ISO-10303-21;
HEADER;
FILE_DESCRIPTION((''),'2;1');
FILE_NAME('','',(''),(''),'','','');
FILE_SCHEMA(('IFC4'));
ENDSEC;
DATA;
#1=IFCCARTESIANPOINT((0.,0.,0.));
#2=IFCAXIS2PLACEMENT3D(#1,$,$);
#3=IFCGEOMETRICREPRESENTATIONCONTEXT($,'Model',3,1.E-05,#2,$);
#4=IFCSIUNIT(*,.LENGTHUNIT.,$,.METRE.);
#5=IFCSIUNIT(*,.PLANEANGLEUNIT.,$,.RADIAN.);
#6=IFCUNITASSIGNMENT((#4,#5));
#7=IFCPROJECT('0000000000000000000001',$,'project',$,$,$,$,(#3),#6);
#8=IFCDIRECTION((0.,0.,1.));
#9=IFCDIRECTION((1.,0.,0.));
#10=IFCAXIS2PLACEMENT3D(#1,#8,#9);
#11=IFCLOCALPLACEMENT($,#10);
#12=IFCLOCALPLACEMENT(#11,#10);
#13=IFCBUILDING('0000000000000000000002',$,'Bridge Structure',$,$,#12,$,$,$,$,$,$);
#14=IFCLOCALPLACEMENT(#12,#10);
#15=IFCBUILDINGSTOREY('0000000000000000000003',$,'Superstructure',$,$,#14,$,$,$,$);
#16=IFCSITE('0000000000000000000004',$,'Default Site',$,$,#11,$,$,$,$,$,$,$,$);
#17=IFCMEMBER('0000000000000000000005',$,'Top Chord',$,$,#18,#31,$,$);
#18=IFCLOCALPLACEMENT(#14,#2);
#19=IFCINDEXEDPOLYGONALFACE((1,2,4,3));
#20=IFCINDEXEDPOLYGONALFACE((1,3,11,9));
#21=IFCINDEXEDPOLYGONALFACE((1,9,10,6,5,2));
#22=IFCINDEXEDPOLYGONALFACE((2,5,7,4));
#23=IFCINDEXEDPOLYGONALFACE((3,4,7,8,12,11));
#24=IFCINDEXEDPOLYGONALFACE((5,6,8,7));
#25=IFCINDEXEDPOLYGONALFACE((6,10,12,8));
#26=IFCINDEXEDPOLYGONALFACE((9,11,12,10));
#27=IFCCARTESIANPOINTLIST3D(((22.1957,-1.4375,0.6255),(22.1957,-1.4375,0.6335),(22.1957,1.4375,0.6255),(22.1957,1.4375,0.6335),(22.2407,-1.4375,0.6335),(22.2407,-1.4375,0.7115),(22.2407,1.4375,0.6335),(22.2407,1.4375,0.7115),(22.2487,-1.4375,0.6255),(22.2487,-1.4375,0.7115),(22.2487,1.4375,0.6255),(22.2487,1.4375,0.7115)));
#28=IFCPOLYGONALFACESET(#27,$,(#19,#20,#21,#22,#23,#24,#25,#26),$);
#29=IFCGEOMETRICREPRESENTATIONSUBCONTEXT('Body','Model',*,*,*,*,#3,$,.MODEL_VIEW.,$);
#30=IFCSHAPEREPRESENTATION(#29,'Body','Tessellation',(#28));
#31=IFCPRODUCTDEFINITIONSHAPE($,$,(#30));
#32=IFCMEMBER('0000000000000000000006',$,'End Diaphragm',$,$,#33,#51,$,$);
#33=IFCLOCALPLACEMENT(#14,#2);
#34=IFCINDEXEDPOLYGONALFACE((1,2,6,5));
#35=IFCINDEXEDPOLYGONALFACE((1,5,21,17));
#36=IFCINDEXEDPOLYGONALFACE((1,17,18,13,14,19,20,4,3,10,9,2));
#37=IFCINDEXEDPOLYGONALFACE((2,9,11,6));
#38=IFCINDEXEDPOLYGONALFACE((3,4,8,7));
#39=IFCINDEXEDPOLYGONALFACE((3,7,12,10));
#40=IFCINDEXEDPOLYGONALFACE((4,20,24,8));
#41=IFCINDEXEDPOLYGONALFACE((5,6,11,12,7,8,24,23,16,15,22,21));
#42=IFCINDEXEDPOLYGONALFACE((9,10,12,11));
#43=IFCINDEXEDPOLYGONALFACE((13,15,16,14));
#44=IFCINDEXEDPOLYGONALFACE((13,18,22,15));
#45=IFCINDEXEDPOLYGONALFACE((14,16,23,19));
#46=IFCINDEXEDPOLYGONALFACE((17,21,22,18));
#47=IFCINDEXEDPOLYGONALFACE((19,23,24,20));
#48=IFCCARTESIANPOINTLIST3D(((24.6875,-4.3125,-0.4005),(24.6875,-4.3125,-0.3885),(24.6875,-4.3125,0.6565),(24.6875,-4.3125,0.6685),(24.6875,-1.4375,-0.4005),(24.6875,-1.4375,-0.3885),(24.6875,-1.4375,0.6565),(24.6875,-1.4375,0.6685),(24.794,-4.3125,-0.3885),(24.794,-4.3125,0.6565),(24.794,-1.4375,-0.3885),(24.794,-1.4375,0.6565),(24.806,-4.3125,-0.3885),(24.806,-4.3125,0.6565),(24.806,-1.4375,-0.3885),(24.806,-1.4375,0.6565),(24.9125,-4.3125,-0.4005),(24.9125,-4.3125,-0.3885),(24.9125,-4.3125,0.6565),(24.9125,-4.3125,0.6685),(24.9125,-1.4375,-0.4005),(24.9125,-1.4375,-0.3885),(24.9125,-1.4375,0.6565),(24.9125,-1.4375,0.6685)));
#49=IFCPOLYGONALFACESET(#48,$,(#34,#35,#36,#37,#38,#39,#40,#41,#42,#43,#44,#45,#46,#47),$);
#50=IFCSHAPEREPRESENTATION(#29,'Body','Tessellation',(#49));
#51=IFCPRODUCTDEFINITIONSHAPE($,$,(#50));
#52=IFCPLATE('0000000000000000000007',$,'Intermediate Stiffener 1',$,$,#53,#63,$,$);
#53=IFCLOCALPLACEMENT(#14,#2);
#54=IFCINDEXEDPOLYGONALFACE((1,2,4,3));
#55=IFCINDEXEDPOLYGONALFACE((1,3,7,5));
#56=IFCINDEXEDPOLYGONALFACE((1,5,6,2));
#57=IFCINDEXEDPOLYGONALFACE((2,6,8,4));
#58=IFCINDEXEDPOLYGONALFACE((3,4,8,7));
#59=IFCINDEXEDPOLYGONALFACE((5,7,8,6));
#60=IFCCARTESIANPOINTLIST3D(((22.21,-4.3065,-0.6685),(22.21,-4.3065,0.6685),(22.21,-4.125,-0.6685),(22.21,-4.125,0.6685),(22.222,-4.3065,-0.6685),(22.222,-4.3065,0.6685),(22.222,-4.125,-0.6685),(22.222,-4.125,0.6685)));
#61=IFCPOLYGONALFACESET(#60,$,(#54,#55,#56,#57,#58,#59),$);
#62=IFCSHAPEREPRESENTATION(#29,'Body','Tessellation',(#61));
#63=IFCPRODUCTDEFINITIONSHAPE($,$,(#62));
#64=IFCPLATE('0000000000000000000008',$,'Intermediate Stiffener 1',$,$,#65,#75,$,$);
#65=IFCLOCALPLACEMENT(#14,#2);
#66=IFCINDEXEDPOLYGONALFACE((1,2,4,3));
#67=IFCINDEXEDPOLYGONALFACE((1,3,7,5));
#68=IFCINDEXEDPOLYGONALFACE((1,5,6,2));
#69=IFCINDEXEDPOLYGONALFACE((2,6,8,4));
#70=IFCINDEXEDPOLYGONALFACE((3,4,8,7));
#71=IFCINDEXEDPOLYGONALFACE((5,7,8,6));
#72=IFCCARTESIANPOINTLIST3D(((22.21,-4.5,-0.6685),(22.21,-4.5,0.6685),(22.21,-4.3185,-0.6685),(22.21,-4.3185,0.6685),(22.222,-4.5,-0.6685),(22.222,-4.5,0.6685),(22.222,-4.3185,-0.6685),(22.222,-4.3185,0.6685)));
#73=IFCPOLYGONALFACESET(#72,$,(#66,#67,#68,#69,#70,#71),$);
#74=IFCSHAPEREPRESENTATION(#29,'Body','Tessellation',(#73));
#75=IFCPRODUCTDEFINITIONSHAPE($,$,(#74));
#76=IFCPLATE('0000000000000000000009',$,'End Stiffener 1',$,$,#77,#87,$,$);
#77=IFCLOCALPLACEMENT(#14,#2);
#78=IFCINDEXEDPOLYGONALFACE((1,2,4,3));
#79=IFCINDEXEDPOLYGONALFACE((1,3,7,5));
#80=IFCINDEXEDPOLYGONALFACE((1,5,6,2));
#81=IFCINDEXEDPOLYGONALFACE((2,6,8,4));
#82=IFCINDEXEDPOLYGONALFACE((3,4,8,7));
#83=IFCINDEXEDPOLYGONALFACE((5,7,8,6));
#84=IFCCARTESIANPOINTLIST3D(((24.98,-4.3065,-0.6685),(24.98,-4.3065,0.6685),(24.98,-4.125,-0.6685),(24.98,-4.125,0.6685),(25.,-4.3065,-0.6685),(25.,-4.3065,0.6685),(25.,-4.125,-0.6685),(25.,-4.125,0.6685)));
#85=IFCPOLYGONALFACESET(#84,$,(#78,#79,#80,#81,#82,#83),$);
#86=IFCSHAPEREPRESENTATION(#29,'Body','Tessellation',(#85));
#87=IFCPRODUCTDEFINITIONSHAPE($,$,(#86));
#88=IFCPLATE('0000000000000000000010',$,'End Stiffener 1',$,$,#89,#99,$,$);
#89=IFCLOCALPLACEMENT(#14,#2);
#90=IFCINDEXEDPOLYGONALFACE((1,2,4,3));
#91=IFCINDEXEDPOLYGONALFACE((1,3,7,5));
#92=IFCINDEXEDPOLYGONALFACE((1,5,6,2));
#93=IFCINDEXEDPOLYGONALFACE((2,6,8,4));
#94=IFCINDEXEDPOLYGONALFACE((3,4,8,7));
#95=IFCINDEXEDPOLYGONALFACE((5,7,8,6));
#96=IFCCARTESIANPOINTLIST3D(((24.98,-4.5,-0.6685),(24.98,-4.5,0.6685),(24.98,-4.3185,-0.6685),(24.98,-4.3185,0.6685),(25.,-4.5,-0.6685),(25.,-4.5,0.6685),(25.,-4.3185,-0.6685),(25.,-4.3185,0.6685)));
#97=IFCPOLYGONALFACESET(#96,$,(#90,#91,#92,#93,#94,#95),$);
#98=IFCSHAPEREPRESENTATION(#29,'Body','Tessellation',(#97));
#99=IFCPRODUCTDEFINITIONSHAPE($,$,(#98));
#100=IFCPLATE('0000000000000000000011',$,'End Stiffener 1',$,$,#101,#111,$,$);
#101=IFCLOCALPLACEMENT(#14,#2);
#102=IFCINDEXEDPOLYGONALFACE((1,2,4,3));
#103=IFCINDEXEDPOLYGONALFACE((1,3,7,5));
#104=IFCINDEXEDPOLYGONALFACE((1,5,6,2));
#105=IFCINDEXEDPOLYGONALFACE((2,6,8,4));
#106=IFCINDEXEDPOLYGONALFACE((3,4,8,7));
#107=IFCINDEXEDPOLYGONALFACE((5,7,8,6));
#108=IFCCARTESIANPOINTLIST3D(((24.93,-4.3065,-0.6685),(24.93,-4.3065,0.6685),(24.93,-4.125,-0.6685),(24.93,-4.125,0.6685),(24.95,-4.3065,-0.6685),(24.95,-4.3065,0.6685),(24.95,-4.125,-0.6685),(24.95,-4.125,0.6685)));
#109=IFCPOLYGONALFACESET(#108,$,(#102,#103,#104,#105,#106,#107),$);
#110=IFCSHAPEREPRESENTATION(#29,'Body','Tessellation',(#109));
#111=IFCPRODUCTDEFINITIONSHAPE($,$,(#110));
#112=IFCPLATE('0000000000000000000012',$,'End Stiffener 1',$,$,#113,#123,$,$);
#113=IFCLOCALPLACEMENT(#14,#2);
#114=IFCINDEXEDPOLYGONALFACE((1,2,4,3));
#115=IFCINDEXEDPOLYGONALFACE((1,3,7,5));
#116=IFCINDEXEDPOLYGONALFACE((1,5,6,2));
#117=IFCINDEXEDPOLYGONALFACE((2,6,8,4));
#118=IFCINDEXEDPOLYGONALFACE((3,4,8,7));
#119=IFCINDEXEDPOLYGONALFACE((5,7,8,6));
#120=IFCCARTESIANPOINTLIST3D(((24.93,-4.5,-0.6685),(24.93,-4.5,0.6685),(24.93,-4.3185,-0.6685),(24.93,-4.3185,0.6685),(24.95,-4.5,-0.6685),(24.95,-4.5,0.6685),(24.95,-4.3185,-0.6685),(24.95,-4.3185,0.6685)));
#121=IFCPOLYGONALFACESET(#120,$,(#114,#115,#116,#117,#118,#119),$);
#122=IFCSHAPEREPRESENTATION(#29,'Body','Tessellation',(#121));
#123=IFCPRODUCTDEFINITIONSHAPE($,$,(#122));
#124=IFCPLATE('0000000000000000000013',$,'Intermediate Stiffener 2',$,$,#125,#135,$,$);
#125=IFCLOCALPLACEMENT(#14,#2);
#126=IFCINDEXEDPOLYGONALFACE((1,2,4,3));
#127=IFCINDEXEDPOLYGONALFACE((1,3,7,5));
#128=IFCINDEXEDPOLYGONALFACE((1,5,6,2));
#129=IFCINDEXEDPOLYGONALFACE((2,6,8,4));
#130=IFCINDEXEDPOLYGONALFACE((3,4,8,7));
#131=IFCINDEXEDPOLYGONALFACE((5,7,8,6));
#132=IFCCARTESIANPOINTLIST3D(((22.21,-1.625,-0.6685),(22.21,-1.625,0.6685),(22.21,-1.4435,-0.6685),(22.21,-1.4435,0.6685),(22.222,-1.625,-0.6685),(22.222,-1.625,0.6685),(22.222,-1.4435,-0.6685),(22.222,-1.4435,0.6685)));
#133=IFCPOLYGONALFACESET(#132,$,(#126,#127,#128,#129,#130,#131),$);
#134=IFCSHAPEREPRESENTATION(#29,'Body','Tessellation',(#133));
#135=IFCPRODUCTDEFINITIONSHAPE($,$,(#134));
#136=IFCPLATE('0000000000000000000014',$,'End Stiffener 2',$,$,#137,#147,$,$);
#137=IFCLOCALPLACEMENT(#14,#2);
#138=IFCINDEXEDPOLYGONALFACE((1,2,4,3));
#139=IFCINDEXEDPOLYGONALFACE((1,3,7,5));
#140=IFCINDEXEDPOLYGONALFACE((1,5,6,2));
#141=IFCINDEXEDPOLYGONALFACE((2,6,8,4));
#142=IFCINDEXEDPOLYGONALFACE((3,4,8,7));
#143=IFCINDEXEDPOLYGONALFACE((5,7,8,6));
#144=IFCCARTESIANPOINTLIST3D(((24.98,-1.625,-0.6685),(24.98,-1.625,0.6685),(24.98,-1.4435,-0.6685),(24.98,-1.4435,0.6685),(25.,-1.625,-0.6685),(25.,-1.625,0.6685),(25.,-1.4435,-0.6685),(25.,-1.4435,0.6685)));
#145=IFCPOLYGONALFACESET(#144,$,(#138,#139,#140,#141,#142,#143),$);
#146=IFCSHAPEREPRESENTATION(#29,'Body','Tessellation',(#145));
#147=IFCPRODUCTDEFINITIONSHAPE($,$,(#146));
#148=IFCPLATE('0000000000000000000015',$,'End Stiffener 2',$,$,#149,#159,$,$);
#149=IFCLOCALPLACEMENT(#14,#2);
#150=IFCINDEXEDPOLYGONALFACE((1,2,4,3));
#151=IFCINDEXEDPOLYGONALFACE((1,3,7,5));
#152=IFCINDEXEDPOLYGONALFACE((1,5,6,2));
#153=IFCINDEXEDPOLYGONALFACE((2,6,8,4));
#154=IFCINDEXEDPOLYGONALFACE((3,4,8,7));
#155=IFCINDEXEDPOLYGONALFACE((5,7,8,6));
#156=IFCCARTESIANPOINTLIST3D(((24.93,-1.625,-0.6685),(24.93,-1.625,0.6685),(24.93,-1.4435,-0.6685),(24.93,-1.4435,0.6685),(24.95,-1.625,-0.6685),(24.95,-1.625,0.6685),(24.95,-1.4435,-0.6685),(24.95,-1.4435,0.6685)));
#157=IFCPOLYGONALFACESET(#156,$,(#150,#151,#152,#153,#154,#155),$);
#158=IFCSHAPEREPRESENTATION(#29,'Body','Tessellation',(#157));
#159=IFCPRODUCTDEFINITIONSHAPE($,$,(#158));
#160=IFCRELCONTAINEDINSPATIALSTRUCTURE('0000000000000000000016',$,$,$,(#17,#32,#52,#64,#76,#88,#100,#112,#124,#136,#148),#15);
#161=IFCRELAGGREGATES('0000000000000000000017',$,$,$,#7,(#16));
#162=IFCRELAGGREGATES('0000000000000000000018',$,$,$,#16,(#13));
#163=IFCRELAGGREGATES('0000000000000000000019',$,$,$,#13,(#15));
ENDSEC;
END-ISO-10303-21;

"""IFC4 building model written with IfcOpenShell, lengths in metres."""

from ifc_helpers import new_model, si_unit, frame, origin, origin_with_axes, origin_2d_with_axis, place, context, subcontext, project, spatial, rectangle, i_section, l_section, extrude, element, save


model = new_model("IFC4")

# Units and contexts
model_context = context("Model", 3, precision=1e-05, world=origin())
body_context = subcontext(model_context, "Body", "Model", "MODEL_VIEW")
ifc_project = project(units=[si_unit("LENGTHUNIT", "METRE"), si_unit("PLANEANGLEUNIT", "RADIAN")], contexts=[model_context])

# Site, building, storey
site_placement = place(None, origin_with_axes())
site = spatial("IfcSite", under=ifc_project, at=site_placement, Name="Default Site")
building_placement = place(site_placement, origin_with_axes())
building = spatial("IfcBuilding", under=site, at=building_placement, Name="Bridge Structure")
storey_placement = place(building_placement, origin_with_axes())
storey = spatial("IfcBuildingStorey", under=building, at=storey_placement, Name="Superstructure")

# Members
for number, where, z_axis, x_axis, name in (
    (1, (22.2222, -1.4375, 0.6685), (0.0, 1.0, 0.0), (-1.0, 0.0, 0.0), "Top Chord"),
):
    element("IfcMember", number, at=place(storey_placement, frame(where, z_axis=z_axis, x_axis=x_axis)), inside=storey, Name=name, context=body_context, shape_type="SweptSolid", body=[
        extrude(l_section(Depth=0.086, Width=0.053, Thickness=0.008, at=origin_2d_with_axis()), origin_with_axes(), (0.0, 0.0, 1.0), 2.875),
    ])
member_placement = place(storey_placement, frame((24.8, -4.3125, 0.134), z_axis=(0.0, 1.0, 0.0), x_axis=(-1.0, 0.0, 0.0)))
element("IfcMember", 2, at=member_placement, inside=storey, Name="End Diaphragm", context=body_context, shape_type="SweptSolid", body=[
    extrude(i_section(OverallWidth=0.225, OverallDepth=1.069, WebThickness=0.012, FlangeThickness=0.012, at=origin_2d_with_axis()), origin_with_axes(), (0.0, 0.0, 1.0), 2.875),
])

# Plates
for number, where, z_axis, x_axis, name in (
    (3, (22.216, -4.2157, -0.6685), (0.0, 0.0, 1.0), (1.0, 0.0, 0.0), "Intermediate Stiffener 1"),
    (4, (22.216, -4.4093, -0.6685), (0.0, 0.0, 1.0), (1.0, 0.0, 0.0), "Intermediate Stiffener 1"),
):
    element("IfcPlate", number, at=place(storey_placement, frame(where, z_axis=z_axis, x_axis=x_axis)), inside=storey, Name=name, context=body_context, shape_type="SweptSolid", body=[
        extrude(rectangle(XDim=0.012, YDim=0.1815, at=origin_2d_with_axis()), origin_with_axes(), (0.0, 0.0, 1.0), 1.337),
    ])
for number, where, z_axis, x_axis, name in (
    (5, (24.99, -4.2157, -0.6685), (0.0, 0.0, 1.0), (1.0, 0.0, 0.0), "End Stiffener 1"),
    (6, (24.99, -4.4093, -0.6685), (0.0, 0.0, 1.0), (1.0, 0.0, 0.0), "End Stiffener 1"),
    (7, (24.94, -4.2157, -0.6685), (0.0, 0.0, 1.0), (1.0, 0.0, 0.0), "End Stiffener 1"),
    (8, (24.94, -4.4093, -0.6685), (0.0, 0.0, 1.0), (1.0, 0.0, 0.0), "End Stiffener 1"),
):
    element("IfcPlate", number, at=place(storey_placement, frame(where, z_axis=z_axis, x_axis=x_axis)), inside=storey, Name=name, context=body_context, shape_type="SweptSolid", body=[
        extrude(rectangle(XDim=0.02, YDim=0.1815, at=origin_2d_with_axis()), origin_with_axes(), (0.0, 0.0, 1.0), 1.337),
    ])
plate_placement = place(storey_placement, frame((22.216, -1.5343, -0.6685), z_axis=(0.0, 0.0, 1.0), x_axis=(1.0, 0.0, 0.0)))
element("IfcPlate", 9, at=plate_placement, inside=storey, Name="Intermediate Stiffener 2", context=body_context, shape_type="SweptSolid", body=[
    extrude(rectangle(XDim=0.012, YDim=0.1815, at=origin_2d_with_axis()), origin_with_axes(), (0.0, 0.0, 1.0), 1.337),
])
for number, where, z_axis, x_axis, name in (
    (10, (24.99, -1.5343, -0.6685), (0.0, 0.0, 1.0), (1.0, 0.0, 0.0), "End Stiffener 2"),
    (11, (24.94, -1.5343, -0.6685), (0.0, 0.0, 1.0), (1.0, 0.0, 0.0), "End Stiffener 2"),
):
    element("IfcPlate", number, at=place(storey_placement, frame(where, z_axis=z_axis, x_axis=x_axis)), inside=storey, Name=name, context=body_context, shape_type="SweptSolid", body=[
        extrude(rectangle(XDim=0.02, YDim=0.1815, at=origin_2d_with_axis()), origin_with_axes(), (0.0, 0.0, 1.0), 1.337),
    ])

save(model, "model.ifc")
